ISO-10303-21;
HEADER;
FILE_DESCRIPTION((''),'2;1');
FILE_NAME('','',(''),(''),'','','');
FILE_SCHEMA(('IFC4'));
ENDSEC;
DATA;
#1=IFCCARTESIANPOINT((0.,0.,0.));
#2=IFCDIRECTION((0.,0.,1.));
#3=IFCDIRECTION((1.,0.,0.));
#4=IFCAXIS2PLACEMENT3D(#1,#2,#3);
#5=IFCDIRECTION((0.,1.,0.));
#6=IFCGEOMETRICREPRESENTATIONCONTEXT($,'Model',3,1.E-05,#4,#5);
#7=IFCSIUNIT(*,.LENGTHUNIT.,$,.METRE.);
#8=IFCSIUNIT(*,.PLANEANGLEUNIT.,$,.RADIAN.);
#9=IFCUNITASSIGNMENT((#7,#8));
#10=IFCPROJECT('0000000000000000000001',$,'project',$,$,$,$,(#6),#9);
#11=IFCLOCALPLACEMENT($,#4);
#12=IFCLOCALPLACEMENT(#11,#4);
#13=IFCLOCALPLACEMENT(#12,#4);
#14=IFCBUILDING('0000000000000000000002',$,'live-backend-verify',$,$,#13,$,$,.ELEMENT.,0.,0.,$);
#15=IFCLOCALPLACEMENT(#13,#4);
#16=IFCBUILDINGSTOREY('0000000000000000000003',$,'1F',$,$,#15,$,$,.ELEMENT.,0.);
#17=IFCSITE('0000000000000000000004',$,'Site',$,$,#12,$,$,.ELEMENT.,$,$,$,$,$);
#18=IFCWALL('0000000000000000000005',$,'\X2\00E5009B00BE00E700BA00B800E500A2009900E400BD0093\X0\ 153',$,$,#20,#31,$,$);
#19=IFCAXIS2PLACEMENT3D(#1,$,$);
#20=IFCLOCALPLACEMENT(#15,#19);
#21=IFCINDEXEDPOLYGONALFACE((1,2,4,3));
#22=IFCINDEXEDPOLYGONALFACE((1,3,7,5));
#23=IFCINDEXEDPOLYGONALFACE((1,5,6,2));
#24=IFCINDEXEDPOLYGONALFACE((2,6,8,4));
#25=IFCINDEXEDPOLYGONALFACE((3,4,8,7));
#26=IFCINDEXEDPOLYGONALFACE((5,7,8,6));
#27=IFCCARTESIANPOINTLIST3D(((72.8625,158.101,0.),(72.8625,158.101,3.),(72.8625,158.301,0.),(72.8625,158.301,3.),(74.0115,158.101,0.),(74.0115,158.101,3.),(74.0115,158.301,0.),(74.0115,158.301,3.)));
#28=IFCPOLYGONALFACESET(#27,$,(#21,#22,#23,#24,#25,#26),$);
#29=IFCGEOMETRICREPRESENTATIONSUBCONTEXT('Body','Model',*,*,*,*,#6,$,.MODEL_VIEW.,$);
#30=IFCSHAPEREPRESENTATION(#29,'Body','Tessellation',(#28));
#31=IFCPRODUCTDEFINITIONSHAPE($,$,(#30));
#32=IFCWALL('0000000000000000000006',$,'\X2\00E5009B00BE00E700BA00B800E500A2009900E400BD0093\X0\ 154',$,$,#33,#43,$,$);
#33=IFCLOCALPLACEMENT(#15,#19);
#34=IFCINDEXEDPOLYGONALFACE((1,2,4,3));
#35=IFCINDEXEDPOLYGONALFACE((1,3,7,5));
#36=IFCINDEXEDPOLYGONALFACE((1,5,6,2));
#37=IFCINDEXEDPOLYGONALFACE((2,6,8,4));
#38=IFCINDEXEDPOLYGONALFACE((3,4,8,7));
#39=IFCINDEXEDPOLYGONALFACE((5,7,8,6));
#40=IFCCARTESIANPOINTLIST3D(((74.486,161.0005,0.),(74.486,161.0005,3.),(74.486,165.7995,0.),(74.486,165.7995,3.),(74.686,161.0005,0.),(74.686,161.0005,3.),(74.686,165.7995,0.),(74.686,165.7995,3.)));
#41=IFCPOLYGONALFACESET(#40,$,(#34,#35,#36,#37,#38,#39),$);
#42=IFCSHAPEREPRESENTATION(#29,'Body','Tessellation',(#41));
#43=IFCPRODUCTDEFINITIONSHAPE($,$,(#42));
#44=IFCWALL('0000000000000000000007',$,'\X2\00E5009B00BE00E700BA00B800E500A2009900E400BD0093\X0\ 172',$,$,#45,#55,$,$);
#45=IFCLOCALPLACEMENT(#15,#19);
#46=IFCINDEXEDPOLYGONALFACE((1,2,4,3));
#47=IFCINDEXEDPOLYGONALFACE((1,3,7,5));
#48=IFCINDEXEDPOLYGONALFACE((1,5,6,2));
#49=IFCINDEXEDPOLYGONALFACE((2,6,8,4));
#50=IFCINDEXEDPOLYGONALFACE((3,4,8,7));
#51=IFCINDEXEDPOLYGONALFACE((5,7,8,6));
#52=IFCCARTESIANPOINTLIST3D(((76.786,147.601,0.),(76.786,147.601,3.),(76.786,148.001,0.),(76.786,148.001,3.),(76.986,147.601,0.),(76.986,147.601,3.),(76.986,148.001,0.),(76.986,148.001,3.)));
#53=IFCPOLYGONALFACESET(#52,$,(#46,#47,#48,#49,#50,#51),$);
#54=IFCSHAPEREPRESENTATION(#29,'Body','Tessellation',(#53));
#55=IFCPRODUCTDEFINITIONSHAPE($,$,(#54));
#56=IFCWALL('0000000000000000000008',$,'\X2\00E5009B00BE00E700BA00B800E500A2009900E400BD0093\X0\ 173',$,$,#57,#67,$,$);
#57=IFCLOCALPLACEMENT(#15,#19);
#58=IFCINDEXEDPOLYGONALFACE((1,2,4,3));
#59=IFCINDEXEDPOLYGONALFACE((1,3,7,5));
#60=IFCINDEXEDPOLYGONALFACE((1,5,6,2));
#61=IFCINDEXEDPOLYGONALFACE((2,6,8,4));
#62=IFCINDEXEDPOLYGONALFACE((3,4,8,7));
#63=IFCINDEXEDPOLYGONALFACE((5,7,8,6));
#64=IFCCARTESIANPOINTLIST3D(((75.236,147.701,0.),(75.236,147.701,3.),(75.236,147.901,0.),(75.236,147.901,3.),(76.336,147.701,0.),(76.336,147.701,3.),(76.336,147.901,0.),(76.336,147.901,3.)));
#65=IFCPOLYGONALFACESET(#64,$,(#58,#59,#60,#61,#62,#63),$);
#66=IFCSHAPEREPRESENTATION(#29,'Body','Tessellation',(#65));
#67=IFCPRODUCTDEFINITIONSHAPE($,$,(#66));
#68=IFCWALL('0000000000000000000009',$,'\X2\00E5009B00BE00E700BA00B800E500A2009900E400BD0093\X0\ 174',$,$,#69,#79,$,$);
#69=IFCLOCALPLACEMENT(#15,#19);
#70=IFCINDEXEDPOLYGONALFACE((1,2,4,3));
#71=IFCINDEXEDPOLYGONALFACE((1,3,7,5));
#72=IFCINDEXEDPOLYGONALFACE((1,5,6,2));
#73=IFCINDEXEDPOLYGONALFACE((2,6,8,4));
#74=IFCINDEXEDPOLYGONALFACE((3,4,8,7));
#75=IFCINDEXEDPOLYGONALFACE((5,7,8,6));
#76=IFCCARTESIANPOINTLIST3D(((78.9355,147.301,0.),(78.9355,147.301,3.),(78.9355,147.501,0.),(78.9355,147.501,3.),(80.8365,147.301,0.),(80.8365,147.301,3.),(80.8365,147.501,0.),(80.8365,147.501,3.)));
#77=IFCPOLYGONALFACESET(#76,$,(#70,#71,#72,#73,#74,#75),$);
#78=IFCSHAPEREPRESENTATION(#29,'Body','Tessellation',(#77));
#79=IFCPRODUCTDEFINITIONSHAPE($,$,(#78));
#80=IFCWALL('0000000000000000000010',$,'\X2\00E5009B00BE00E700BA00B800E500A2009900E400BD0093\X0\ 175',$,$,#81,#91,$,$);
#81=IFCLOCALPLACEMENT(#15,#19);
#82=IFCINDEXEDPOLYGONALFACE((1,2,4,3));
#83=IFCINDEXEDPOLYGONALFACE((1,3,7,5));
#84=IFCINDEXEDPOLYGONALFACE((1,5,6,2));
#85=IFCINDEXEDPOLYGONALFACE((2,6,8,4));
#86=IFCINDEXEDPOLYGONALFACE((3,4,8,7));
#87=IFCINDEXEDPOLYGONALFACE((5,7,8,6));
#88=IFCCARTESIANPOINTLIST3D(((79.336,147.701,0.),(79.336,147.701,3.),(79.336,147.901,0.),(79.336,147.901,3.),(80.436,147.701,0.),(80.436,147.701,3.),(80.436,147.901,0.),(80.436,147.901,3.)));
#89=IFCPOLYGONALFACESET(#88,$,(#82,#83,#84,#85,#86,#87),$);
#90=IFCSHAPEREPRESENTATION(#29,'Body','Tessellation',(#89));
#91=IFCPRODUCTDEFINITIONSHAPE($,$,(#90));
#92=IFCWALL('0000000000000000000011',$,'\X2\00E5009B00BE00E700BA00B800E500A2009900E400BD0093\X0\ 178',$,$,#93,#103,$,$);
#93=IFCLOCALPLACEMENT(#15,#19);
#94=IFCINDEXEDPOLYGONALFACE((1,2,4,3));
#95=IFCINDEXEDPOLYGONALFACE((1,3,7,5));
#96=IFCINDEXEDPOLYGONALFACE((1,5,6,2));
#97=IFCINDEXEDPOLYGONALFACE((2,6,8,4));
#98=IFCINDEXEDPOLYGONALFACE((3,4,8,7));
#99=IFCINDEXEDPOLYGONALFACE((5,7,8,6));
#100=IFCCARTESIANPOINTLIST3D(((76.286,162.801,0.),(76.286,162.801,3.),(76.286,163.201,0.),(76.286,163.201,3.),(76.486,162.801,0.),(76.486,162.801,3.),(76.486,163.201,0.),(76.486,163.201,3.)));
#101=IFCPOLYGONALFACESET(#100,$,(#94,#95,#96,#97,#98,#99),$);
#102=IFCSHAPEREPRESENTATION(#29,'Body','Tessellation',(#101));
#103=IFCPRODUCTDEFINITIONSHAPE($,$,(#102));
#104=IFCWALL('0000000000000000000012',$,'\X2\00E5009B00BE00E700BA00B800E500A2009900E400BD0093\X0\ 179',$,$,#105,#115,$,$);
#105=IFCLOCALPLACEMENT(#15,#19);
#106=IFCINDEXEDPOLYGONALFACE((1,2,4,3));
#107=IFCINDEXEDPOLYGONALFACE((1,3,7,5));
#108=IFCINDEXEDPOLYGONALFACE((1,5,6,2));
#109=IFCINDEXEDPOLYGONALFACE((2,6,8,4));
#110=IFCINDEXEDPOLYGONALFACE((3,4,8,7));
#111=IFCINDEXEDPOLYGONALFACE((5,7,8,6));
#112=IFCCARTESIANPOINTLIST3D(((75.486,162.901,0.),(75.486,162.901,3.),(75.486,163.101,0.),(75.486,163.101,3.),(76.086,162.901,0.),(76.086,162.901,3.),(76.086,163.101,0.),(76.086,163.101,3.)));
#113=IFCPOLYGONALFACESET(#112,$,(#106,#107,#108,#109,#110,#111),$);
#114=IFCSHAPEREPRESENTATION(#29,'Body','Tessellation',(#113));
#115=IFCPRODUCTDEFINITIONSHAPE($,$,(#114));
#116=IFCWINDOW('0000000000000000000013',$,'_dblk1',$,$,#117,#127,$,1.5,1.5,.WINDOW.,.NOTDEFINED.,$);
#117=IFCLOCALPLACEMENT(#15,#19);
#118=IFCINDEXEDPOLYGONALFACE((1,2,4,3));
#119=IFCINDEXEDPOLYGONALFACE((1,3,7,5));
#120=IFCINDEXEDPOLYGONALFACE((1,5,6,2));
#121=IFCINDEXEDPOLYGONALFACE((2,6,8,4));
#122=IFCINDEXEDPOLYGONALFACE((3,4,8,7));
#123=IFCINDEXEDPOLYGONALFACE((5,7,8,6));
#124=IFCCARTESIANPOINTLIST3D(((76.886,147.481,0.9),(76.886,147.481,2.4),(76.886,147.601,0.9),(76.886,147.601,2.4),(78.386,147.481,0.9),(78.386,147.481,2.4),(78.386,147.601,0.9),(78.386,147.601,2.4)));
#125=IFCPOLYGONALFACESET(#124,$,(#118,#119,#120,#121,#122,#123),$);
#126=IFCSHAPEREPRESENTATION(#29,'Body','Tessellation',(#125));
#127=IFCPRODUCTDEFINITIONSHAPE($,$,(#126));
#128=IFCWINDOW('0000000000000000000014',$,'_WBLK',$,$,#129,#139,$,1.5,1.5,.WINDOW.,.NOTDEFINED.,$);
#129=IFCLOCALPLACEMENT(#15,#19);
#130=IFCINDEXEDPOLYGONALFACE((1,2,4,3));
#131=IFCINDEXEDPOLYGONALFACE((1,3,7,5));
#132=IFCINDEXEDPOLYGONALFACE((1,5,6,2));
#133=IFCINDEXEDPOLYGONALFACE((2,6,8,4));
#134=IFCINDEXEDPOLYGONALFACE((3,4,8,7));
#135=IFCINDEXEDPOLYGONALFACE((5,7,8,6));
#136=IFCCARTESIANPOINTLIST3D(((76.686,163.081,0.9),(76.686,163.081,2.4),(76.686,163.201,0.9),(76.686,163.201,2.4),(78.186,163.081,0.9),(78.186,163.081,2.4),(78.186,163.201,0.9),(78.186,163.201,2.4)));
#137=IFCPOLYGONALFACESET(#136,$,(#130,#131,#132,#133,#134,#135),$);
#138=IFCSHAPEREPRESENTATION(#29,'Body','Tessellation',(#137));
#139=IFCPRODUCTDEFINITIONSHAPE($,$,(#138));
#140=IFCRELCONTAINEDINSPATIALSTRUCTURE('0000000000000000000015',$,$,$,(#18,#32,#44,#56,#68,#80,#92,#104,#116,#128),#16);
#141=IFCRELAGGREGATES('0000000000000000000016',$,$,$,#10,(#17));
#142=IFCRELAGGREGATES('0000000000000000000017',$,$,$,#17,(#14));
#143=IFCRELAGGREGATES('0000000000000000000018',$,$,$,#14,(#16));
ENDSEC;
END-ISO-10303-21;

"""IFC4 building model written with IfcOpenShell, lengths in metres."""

from ifc_helpers import new_model, si_unit, direction, frame, frame_2d, origin_with_axes, place, context, subcontext, project, spatial, rectangle, extrude, element, save


model = new_model("IFC4")

# Units and contexts
model_context = context("Model", 3, precision=1e-05, world=origin_with_axes(), true_north=direction((0.0, 1.0, 0.0)))
body_context = subcontext(model_context, "Body", "Model", "MODEL_VIEW")
ifc_project = project(units=[si_unit("LENGTHUNIT", "METRE"), si_unit("PLANEANGLEUNIT", "RADIAN")], contexts=[model_context])

# Site, building, storey
placement = place(None, origin_with_axes())
site_placement = place(placement, origin_with_axes())
site = spatial("IfcSite", under=ifc_project, at=site_placement, Name="Site", CompositionType="ELEMENT")
building_placement = place(site_placement, origin_with_axes())
building = spatial("IfcBuilding", under=site, at=building_placement, Name="live-backend-verify", CompositionType="ELEMENT", ElevationOfRefHeight=0.0, ElevationOfTerrain=0.0)
storey_placement = place(building_placement, origin_with_axes())
storey = spatial("IfcBuildingStorey", under=building, at=storey_placement, Name="1F", CompositionType="ELEMENT", Elevation=0.0)

# Walls
for number, where, z_axis, x_axis, name in (
    (1, (73.437, 158.201, 0.0), (0.0, 0.0, 1.0), (1.0, 0.0, 0.0), "å\u009b¾çº¸å¢\u0099ä½\u0093 153"),
):
    element("IfcWall", number, at=place(storey_placement, frame(where, z_axis=z_axis, x_axis=x_axis)), inside=storey, Name=name, context=body_context, shape_type="SweptSolid", body=[
        extrude(rectangle(XDim=1.149, YDim=0.2, at=frame_2d((0.0, 0.0), x_axis=(1.0, 0.0, 0.0))), frame((0.0, 0.0, 0.0), z_axis=(0.0, 0.0, 1.0)), (0.0, 0.0, 1.0), 3.0),
    ])
wall_1_placement = place(storey_placement, frame((74.586, 163.4, 0.0), z_axis=(0.0, 0.0, 1.0), x_axis=(0.0, -1.0, 0.0)))
element("IfcWall", 2, at=wall_1_placement, inside=storey, Name="å\u009b¾çº¸å¢\u0099ä½\u0093 154", context=body_context, shape_type="SweptSolid", body=[
    extrude(rectangle(XDim=4.799, YDim=0.2, at=frame_2d((0.0, 0.0), x_axis=(1.0, 0.0, 0.0))), frame((0.0, 0.0, 0.0), z_axis=(0.0, 0.0, 1.0)), (0.0, 0.0, 1.0), 3.0),
])
wall_2_placement = place(storey_placement, frame((76.886, 147.801, 0.0), z_axis=(0.0, 0.0, 1.0), x_axis=(0.0, -1.0, 0.0)))
element("IfcWall", 3, at=wall_2_placement, inside=storey, Name="å\u009b¾çº¸å¢\u0099ä½\u0093 172", context=body_context, shape_type="SweptSolid", body=[
    extrude(rectangle(XDim=0.4, YDim=0.2, at=frame_2d((0.0, 0.0), x_axis=(1.0, 0.0, 0.0))), frame((0.0, 0.0, 0.0), z_axis=(0.0, 0.0, 1.0)), (0.0, 0.0, 1.0), 3.0),
])
wall_3_placement = place(storey_placement, frame((75.786, 147.801, 0.0), z_axis=(0.0, 0.0, 1.0), x_axis=(1.0, 0.0, 0.0)))
element("IfcWall", 4, at=wall_3_placement, inside=storey, Name="å\u009b¾çº¸å¢\u0099ä½\u0093 173", context=body_context, shape_type="SweptSolid", body=[
    extrude(rectangle(XDim=1.1, YDim=0.2, at=frame_2d((0.0, 0.0), x_axis=(1.0, 0.0, 0.0))), frame((0.0, 0.0, 0.0), z_axis=(0.0, 0.0, 1.0)), (0.0, 0.0, 1.0), 3.0),
])
wall_4_placement = place(storey_placement, frame((79.886, 147.401, 0.0), z_axis=(0.0, 0.0, 1.0), x_axis=(1.0, 0.0, 0.0)))
element("IfcWall", 5, at=wall_4_placement, inside=storey, Name="å\u009b¾çº¸å¢\u0099ä½\u0093 174", context=body_context, shape_type="SweptSolid", body=[
    extrude(rectangle(XDim=1.901, YDim=0.2, at=frame_2d((0.0, 0.0), x_axis=(1.0, 0.0, 0.0))), frame((0.0, 0.0, 0.0), z_axis=(0.0, 0.0, 1.0)), (0.0, 0.0, 1.0), 3.0),
])
wall_5_placement = place(storey_placement, frame((79.886, 147.801, 0.0), z_axis=(0.0, 0.0, 1.0), x_axis=(1.0, 0.0, 0.0)))
element("IfcWall", 6, at=wall_5_placement, inside=storey, Name="å\u009b¾çº¸å¢\u0099ä½\u0093 175", context=body_context, shape_type="SweptSolid", body=[
    extrude(rectangle(XDim=1.1, YDim=0.2, at=frame_2d((0.0, 0.0), x_axis=(1.0, 0.0, 0.0))), frame((0.0, 0.0, 0.0), z_axis=(0.0, 0.0, 1.0)), (0.0, 0.0, 1.0), 3.0),
])
wall_6_placement = place(storey_placement, frame((76.386, 163.001, 0.0), z_axis=(0.0, 0.0, 1.0), x_axis=(0.0, 1.0, 0.0)))
element("IfcWall", 7, at=wall_6_placement, inside=storey, Name="å\u009b¾çº¸å¢\u0099ä½\u0093 178", context=body_context, shape_type="SweptSolid", body=[
    extrude(rectangle(XDim=0.4, YDim=0.2, at=frame_2d((0.0, 0.0), x_axis=(1.0, 0.0, 0.0))), frame((0.0, 0.0, 0.0), z_axis=(0.0, 0.0, 1.0)), (0.0, 0.0, 1.0), 3.0),
])
wall_7_placement = place(storey_placement, frame((75.786, 163.001, 0.0), z_axis=(0.0, 0.0, 1.0), x_axis=(1.0, 0.0, 0.0)))
element("IfcWall", 8, at=wall_7_placement, inside=storey, Name="å\u009b¾çº¸å¢\u0099ä½\u0093 179", context=body_context, shape_type="SweptSolid", body=[
    extrude(rectangle(XDim=0.6, YDim=0.2, at=frame_2d((0.0, 0.0), x_axis=(1.0, 0.0, 0.0))), frame((0.0, 0.0, 0.0), z_axis=(0.0, 0.0, 1.0)), (0.0, 0.0, 1.0), 3.0),
])

# Windows
for number, where, z_axis, x_axis, name in (
    (9, (77.636, 147.541, 0.9), (0.0, 0.0, 1.0), (1.0, 0.0, 0.0), "_dblk1"),
    (10, (77.436, 163.141, 0.9), (0.0, 0.0, 1.0), (1.0, 0.0, 0.0), "_WBLK"),
):
    element("IfcWindow", number, at=place(storey_placement, frame(where, z_axis=z_axis, x_axis=x_axis)), inside=storey, Name=name, OverallHeight=1.5, OverallWidth=1.5, PartitioningType="NOTDEFINED", PredefinedType="WINDOW", context=body_context, shape_type="SweptSolid", body=[
        extrude(rectangle(XDim=1.5, YDim=0.12, at=frame_2d((0.0, 0.0), x_axis=(1.0, 0.0, 0.0))), frame((0.0, 0.0, 0.0), z_axis=(0.0, 0.0, 1.0)), (0.0, 0.0, 1.0), 1.5),
    ])

save(model, "model.ifc")
